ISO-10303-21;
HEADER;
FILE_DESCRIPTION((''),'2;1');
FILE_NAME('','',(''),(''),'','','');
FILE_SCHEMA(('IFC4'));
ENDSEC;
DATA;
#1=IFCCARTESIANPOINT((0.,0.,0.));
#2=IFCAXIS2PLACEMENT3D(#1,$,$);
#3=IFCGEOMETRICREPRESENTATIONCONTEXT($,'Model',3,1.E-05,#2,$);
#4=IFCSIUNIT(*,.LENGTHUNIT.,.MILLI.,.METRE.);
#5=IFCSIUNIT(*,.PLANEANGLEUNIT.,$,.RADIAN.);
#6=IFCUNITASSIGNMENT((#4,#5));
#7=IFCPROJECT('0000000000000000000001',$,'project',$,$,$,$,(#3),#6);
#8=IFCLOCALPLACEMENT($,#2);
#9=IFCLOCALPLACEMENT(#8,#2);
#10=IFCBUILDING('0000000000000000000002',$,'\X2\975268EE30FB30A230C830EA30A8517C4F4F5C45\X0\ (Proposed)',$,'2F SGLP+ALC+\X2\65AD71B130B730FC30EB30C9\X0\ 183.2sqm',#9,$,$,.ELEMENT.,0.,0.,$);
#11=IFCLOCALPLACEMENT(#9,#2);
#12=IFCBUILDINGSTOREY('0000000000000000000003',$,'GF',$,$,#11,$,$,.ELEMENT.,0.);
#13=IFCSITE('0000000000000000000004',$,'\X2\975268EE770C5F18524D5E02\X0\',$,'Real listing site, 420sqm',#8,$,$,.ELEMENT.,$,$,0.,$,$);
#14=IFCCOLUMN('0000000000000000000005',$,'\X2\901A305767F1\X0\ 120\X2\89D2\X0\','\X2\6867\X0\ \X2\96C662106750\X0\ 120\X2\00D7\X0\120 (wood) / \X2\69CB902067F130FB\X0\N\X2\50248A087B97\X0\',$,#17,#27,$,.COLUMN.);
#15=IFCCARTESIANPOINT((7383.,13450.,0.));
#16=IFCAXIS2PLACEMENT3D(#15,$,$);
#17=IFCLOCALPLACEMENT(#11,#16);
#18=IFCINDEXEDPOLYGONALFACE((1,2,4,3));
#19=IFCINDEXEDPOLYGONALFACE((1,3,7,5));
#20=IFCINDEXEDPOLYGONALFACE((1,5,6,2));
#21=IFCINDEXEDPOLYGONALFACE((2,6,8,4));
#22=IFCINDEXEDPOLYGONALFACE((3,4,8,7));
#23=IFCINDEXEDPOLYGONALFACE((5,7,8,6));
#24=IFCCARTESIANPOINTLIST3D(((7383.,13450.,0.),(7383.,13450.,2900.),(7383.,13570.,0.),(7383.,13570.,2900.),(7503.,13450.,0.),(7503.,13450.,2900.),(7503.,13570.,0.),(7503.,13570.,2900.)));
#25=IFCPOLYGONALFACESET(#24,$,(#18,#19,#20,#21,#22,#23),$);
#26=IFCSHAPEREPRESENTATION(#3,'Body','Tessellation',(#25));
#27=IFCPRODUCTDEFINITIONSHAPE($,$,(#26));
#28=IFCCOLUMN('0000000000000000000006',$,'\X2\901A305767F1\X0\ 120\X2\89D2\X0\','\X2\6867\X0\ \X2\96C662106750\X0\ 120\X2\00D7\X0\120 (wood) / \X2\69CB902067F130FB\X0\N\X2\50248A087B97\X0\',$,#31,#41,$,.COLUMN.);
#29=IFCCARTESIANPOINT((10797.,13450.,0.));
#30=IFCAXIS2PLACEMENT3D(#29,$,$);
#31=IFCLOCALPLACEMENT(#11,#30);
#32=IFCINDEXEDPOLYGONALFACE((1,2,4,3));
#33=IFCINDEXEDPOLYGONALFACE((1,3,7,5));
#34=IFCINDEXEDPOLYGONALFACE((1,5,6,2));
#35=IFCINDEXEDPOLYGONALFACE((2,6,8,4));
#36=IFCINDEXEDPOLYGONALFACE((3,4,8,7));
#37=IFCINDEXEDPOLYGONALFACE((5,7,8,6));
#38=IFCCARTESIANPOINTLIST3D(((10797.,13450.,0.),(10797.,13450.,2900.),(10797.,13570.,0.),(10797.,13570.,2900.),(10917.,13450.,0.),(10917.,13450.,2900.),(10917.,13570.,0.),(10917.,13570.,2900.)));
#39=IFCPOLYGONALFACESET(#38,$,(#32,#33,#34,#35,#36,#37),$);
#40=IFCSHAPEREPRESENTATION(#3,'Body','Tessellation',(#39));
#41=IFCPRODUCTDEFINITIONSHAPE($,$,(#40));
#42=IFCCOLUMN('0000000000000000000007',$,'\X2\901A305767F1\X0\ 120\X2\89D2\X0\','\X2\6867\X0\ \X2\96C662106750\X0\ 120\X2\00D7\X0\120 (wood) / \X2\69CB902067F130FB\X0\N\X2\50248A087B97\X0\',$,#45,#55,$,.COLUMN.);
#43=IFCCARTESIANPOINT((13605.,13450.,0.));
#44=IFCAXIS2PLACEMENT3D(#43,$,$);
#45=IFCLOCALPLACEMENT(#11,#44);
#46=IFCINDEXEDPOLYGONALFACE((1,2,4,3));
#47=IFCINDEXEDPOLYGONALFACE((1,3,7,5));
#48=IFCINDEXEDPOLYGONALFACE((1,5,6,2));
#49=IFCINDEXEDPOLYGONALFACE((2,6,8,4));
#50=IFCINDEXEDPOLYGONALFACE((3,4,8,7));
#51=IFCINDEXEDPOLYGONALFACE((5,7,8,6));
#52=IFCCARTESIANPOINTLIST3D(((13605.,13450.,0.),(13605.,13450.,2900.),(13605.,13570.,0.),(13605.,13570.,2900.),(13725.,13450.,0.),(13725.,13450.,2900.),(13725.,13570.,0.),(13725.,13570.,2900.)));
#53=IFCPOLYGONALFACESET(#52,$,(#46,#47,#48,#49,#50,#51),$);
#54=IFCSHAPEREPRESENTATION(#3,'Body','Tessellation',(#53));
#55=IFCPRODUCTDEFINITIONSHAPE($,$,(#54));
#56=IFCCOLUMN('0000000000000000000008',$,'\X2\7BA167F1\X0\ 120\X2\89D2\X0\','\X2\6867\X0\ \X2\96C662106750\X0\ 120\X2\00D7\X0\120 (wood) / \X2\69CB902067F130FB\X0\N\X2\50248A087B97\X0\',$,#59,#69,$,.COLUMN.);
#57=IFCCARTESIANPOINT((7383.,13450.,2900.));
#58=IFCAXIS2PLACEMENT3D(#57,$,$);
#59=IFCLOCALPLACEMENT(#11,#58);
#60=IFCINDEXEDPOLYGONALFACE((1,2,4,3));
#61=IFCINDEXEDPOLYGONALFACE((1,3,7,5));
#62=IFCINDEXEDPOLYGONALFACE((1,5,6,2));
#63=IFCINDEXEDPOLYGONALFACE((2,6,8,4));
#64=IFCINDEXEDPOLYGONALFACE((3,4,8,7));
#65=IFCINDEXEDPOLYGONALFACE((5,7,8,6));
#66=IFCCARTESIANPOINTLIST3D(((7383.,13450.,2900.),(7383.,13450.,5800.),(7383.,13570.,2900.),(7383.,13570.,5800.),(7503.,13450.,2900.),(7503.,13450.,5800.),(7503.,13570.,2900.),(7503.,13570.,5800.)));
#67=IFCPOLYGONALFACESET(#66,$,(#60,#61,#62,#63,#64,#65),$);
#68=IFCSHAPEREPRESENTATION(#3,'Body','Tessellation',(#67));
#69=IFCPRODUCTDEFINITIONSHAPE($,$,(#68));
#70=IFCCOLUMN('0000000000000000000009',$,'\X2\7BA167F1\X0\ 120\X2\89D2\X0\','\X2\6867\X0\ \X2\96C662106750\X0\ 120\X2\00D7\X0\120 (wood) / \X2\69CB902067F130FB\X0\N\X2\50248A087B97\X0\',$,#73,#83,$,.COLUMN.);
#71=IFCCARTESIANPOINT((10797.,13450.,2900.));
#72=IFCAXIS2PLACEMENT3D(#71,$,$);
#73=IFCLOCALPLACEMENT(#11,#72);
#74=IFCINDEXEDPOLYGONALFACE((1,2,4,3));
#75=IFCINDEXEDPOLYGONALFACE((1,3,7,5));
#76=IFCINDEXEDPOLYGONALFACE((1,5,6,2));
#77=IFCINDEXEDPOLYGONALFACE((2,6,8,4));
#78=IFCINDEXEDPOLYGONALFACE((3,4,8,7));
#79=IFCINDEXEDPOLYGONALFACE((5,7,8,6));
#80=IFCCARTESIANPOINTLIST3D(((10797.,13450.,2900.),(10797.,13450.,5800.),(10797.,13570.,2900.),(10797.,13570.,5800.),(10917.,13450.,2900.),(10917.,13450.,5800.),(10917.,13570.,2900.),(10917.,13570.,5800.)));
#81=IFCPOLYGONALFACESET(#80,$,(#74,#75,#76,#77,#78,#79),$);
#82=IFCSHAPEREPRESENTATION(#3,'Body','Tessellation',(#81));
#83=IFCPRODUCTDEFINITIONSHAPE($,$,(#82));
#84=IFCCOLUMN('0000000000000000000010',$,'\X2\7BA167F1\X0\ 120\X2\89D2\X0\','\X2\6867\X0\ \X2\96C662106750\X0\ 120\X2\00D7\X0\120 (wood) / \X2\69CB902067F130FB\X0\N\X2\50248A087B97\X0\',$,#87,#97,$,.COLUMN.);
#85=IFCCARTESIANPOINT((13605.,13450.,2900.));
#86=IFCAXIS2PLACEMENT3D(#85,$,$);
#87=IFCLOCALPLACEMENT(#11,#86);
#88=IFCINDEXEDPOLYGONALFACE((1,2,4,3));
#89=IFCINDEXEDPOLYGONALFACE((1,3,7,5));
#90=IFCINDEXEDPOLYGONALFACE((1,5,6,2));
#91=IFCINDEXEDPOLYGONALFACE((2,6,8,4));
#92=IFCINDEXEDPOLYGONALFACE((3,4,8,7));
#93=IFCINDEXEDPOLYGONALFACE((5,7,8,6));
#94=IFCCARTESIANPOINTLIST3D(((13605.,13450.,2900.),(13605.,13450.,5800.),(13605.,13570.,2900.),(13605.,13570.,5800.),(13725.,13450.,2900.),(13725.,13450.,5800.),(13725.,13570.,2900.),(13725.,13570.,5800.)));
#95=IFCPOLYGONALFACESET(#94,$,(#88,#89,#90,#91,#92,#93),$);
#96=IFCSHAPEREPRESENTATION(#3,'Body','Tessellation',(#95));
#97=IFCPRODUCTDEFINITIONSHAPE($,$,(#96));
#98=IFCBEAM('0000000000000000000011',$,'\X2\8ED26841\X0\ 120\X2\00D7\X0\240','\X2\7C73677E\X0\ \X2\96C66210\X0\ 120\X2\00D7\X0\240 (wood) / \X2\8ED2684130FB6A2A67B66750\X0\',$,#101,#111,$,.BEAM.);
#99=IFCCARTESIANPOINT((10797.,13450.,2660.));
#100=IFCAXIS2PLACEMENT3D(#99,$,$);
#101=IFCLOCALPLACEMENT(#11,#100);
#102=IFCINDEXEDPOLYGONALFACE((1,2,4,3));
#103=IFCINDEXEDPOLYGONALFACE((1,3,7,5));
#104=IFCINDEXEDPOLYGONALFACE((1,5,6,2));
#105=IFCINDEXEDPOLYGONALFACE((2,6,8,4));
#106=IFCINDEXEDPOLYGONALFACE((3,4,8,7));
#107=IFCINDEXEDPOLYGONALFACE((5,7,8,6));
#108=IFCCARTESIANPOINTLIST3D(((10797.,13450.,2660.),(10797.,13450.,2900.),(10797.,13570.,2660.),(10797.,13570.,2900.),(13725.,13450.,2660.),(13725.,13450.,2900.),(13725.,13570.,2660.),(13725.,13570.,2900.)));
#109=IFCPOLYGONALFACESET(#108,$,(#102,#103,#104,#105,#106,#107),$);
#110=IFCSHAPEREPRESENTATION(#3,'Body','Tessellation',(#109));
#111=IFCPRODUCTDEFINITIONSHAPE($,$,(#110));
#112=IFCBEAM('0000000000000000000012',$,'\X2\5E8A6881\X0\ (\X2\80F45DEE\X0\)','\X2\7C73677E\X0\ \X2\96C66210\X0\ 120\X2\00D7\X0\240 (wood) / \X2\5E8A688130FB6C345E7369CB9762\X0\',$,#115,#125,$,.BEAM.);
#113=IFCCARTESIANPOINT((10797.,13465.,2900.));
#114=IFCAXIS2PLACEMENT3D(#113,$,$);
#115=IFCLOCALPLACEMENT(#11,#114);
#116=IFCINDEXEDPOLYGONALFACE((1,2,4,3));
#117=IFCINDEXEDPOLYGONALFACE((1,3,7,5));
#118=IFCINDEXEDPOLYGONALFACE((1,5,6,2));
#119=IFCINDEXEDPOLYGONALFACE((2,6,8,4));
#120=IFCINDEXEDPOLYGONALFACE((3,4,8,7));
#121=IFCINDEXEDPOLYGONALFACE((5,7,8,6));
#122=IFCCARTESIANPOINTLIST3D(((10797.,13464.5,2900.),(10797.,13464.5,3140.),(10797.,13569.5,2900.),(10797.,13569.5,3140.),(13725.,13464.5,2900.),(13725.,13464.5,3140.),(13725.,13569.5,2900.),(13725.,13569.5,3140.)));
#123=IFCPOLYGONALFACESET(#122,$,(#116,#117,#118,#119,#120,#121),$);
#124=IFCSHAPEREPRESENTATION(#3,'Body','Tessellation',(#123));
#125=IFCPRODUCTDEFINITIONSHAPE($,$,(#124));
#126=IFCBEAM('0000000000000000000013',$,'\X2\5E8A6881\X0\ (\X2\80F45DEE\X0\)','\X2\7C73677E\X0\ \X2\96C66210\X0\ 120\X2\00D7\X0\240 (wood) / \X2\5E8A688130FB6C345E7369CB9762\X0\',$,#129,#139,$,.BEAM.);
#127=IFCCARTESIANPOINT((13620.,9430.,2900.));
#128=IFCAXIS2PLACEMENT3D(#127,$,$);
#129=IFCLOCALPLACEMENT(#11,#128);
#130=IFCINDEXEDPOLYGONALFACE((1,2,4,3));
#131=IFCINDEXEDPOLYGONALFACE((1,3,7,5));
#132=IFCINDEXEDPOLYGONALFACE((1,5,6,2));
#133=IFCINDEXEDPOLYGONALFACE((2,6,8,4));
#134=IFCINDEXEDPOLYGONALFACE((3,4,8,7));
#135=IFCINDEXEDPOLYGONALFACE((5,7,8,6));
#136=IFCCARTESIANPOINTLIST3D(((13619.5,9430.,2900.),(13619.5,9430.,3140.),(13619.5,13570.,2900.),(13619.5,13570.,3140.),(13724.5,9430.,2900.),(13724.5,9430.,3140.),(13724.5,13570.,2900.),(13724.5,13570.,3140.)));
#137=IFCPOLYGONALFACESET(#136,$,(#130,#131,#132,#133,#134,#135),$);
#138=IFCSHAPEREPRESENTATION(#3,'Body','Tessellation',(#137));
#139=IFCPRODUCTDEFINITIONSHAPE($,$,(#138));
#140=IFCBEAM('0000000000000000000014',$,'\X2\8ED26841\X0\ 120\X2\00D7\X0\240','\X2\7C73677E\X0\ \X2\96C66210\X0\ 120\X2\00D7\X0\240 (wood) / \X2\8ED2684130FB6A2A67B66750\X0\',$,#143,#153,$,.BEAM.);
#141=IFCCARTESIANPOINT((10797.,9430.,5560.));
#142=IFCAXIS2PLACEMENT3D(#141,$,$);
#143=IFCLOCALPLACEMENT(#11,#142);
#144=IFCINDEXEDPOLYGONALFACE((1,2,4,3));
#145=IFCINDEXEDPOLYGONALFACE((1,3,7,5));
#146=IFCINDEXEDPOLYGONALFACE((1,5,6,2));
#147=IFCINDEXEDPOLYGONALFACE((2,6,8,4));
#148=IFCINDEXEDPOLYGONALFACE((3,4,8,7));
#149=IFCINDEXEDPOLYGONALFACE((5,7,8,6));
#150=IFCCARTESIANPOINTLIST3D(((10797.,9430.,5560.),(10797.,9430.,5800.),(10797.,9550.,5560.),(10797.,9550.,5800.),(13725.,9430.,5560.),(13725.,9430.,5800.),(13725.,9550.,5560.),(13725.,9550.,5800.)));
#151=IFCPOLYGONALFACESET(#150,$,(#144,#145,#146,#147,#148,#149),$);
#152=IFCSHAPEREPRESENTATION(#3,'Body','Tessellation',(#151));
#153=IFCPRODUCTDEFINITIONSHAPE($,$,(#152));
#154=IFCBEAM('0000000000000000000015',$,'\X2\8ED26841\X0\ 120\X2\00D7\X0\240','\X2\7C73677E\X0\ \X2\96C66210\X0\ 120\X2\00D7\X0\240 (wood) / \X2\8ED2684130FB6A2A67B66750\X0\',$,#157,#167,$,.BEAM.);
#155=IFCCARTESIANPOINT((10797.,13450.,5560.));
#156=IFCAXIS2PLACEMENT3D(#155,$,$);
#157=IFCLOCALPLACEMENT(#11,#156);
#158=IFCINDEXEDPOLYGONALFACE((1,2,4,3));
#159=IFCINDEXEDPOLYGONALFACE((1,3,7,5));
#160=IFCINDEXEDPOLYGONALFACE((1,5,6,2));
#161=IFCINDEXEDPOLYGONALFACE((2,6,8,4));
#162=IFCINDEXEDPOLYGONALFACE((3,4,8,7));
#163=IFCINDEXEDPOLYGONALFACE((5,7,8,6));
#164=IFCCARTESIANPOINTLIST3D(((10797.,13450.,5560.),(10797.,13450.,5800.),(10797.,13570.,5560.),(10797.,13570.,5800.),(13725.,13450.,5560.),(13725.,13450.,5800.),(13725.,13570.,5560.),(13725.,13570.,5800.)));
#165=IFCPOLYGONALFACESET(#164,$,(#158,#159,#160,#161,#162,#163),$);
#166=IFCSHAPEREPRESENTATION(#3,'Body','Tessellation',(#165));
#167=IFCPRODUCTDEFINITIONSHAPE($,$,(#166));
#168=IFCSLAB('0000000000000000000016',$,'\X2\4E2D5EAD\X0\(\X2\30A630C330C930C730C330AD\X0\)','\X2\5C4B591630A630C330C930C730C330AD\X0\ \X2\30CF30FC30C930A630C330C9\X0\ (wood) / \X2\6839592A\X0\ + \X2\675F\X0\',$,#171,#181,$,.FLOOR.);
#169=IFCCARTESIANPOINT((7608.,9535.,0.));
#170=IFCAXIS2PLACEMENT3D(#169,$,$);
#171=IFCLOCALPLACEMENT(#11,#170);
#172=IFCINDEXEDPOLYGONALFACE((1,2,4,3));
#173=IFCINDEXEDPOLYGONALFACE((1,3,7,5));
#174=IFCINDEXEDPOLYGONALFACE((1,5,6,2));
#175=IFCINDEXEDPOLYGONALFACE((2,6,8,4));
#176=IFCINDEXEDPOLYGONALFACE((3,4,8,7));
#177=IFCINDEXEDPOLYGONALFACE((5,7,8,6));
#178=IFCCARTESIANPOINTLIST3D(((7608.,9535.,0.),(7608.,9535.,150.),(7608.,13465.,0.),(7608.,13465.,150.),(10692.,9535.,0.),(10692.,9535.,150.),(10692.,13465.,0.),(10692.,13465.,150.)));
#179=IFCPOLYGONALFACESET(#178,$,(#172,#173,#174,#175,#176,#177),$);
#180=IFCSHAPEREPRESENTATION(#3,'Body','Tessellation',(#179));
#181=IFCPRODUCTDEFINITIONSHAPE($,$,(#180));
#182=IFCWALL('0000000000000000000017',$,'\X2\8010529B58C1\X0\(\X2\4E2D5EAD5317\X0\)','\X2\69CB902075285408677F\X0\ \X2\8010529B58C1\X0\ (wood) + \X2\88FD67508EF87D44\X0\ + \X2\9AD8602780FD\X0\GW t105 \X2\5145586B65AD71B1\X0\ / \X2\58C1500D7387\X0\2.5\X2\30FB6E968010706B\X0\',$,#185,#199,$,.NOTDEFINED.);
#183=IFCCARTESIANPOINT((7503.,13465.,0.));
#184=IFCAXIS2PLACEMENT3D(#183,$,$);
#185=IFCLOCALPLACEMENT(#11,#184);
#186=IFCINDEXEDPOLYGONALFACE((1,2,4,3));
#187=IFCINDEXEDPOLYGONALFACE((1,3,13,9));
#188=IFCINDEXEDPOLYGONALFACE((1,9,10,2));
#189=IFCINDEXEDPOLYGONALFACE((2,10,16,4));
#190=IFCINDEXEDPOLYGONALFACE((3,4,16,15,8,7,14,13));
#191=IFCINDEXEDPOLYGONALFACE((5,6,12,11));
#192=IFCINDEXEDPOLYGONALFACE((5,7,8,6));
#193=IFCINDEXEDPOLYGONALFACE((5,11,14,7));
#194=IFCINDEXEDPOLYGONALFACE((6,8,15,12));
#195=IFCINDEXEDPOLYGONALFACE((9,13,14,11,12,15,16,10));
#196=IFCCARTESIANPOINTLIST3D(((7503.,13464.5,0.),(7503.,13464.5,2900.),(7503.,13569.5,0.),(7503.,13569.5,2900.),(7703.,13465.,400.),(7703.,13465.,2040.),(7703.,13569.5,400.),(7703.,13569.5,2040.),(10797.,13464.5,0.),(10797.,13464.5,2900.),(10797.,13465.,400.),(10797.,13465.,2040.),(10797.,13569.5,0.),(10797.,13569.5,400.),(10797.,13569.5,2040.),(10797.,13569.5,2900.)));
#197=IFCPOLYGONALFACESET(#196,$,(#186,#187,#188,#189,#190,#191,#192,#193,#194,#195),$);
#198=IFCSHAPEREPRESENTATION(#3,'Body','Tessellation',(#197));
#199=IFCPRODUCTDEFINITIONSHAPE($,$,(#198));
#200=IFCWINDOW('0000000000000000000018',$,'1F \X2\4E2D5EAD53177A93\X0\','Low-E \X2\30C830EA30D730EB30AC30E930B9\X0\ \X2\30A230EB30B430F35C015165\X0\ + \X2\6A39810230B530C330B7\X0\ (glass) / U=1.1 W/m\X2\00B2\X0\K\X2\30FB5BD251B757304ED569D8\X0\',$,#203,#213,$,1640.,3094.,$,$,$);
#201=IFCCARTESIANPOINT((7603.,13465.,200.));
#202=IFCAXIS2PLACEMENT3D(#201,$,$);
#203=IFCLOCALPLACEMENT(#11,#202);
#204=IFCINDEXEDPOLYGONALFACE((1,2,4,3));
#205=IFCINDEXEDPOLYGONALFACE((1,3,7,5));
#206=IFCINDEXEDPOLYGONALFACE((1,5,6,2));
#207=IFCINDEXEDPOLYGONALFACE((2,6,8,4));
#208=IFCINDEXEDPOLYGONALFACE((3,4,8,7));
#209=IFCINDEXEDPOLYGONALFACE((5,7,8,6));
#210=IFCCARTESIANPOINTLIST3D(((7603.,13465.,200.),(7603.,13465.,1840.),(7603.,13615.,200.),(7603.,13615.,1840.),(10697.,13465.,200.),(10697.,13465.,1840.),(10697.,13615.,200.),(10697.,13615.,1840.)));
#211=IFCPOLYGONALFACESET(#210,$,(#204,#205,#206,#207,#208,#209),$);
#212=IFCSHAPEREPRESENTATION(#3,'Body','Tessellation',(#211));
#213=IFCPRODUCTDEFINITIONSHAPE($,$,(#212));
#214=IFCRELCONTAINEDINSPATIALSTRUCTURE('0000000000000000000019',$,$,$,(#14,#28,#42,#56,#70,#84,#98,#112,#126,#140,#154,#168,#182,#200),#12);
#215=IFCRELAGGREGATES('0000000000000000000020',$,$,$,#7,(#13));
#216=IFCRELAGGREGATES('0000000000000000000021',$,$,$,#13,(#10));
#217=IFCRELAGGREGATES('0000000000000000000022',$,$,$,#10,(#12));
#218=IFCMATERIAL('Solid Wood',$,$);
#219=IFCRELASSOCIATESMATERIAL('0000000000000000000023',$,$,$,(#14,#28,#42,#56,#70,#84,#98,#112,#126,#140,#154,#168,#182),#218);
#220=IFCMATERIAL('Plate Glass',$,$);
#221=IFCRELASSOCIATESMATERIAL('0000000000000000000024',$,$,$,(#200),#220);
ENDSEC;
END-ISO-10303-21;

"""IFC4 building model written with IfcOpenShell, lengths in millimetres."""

from ifc_helpers import new_model, si_unit, frame, frame_2d, origin, place, context, project, spatial, rectangle, extrude, material, element, fill, save


model = new_model("IFC4")

# Units and contexts
model_context = context("Model", 3, precision=1e-05, world=origin())
ifc_project = project(units=[si_unit("LENGTHUNIT", "METRE", prefix="MILLI"), si_unit("PLANEANGLEUNIT", "RADIAN")], contexts=[model_context])

# Site, building, storey
site_placement = place(None, origin())
site = spatial("IfcSite", under=ifc_project, at=site_placement, Name="青森県弘前市", ObjectType="Real listing site, 420sqm", CompositionType="ELEMENT", RefElevation=0.0)
building_placement = place(site_placement, origin())
building = spatial("IfcBuilding", under=site, at=building_placement, Name="青森・アトリエ兼住居 (Proposed)", ObjectType="2F SGLP+ALC+断熱シールド 183.2sqm", CompositionType="ELEMENT", ElevationOfRefHeight=0.0, ElevationOfTerrain=0.0)
storey_placement = place(building_placement, origin())
storey = spatial("IfcBuildingStorey", under=building, at=storey_placement, Name="GF", CompositionType="ELEMENT", Elevation=0.0)

# Columns
ifc_material_1 = material(Name="Solid Wood")
column_1_placement = place(storey_placement, frame((7383.0, 13450.0, 0.0)))
element("IfcColumn", 1, at=column_1_placement, inside=storey, material=ifc_material_1, Name="通し柱 120角", Description="桧 集成材 120×120 (wood) / 構造柱・N値計算", PredefinedType="COLUMN", context=model_context, shape_type="SweptSolid", body=[
    extrude(rectangle(XDim=120.0, YDim=120.0, at=frame_2d((60.0, 60.0))), frame((7383.0, 13450.0, 0.0)), (0.0, 0.0, 1.0), 2900.0),
])
column_2_placement = place(storey_placement, frame((10797.0, 13450.0, 0.0)))
element("IfcColumn", 2, at=column_2_placement, inside=storey, material=ifc_material_1, Name="通し柱 120角", Description="桧 集成材 120×120 (wood) / 構造柱・N値計算", PredefinedType="COLUMN", context=model_context, shape_type="SweptSolid", body=[
    extrude(rectangle(XDim=120.0, YDim=120.0, at=frame_2d((60.0, 60.0))), frame((10797.0, 13450.0, 0.0)), (0.0, 0.0, 1.0), 2900.0),
])
column_3_placement = place(storey_placement, frame((13605.0, 13450.0, 0.0)))
element("IfcColumn", 3, at=column_3_placement, inside=storey, material=ifc_material_1, Name="通し柱 120角", Description="桧 集成材 120×120 (wood) / 構造柱・N値計算", PredefinedType="COLUMN", context=model_context, shape_type="SweptSolid", body=[
    extrude(rectangle(XDim=120.0, YDim=120.0, at=frame_2d((60.0, 60.0))), frame((13605.0, 13450.0, 0.0)), (0.0, 0.0, 1.0), 2900.0),
])
column_4_placement = place(storey_placement, frame((7383.0, 13450.0, 2900.0)))
element("IfcColumn", 4, at=column_4_placement, inside=storey, material=ifc_material_1, Name="管柱 120角", Description="桧 集成材 120×120 (wood) / 構造柱・N値計算", PredefinedType="COLUMN", context=model_context, shape_type="SweptSolid", body=[
    extrude(rectangle(XDim=120.0, YDim=120.0, at=frame_2d((60.0, 60.0))), frame((7383.0, 13450.0, 2900.0)), (0.0, 0.0, 1.0), 2900.0),
])
column_5_placement = place(storey_placement, frame((10797.0, 13450.0, 2900.0)))
element("IfcColumn", 5, at=column_5_placement, inside=storey, material=ifc_material_1, Name="管柱 120角", Description="桧 集成材 120×120 (wood) / 構造柱・N値計算", PredefinedType="COLUMN", context=model_context, shape_type="SweptSolid", body=[
    extrude(rectangle(XDim=120.0, YDim=120.0, at=frame_2d((60.0, 60.0))), frame((10797.0, 13450.0, 2900.0)), (0.0, 0.0, 1.0), 2900.0),
])
column_6_placement = place(storey_placement, frame((13605.0, 13450.0, 2900.0)))
element("IfcColumn", 6, at=column_6_placement, inside=storey, material=ifc_material_1, Name="管柱 120角", Description="桧 集成材 120×120 (wood) / 構造柱・N値計算", PredefinedType="COLUMN", context=model_context, shape_type="SweptSolid", body=[
    extrude(rectangle(XDim=120.0, YDim=120.0, at=frame_2d((60.0, 60.0))), frame((13605.0, 13450.0, 2900.0)), (0.0, 0.0, 1.0), 2900.0),
])

# Beams
beam_1_placement = place(storey_placement, frame((10797.0, 13450.0, 2660.0)))
element("IfcBeam", 7, at=beam_1_placement, inside=storey, material=ifc_material_1, Name="軒桁 120×240", Description="米松 集成 120×240 (wood) / 軒桁・横架材", PredefinedType="BEAM", context=model_context, shape_type="SweptSolid", body=[
    extrude(rectangle(XDim=2928.0, YDim=120.0, at=frame_2d((1464.0, 60.0))), frame((10797.0, 13450.0, 2660.0)), (0.0, 0.0, 1.0), 240.0),
])
beam_2_placement = place(storey_placement, frame((10797.0, 13465.0, 2900.0)))
element("IfcBeam", 8, at=beam_2_placement, inside=storey, material=ifc_material_1, Name="床梁 (胴差)", Description="米松 集成 120×240 (wood) / 床梁・水平構面", PredefinedType="BEAM", context=model_context, shape_type="SweptSolid", body=[
    extrude(rectangle(XDim=2928.0, YDim=105.0, at=frame_2d((1464.0, 52.0))), frame((10797.0, 13465.0, 2900.0)), (0.0, 0.0, 1.0), 240.0),
])
beam_3_placement = place(storey_placement, frame((13620.0, 9430.0, 2900.0)))
element("IfcBeam", 9, at=beam_3_placement, inside=storey, material=ifc_material_1, Name="床梁 (胴差)", Description="米松 集成 120×240 (wood) / 床梁・水平構面", PredefinedType="BEAM", context=model_context, shape_type="SweptSolid", body=[
    extrude(rectangle(XDim=105.0, YDim=4140.0, at=frame_2d((52.0, 2070.0))), frame((13620.0, 9430.0, 2900.0)), (0.0, 0.0, 1.0), 240.0),
])
beam_4_placement = place(storey_placement, frame((10797.0, 9430.0, 5560.0)))
element("IfcBeam", 10, at=beam_4_placement, inside=storey, material=ifc_material_1, Name="軒桁 120×240", Description="米松 集成 120×240 (wood) / 軒桁・横架材", PredefinedType="BEAM", context=model_context, shape_type="SweptSolid", body=[
    extrude(rectangle(XDim=2928.0, YDim=120.0, at=frame_2d((1464.0, 60.0))), frame((10797.0, 9430.0, 5560.0)), (0.0, 0.0, 1.0), 240.0),
])
beam_5_placement = place(storey_placement, frame((10797.0, 13450.0, 5560.0)))
element("IfcBeam", 11, at=beam_5_placement, inside=storey, material=ifc_material_1, Name="軒桁 120×240", Description="米松 集成 120×240 (wood) / 軒桁・横架材", PredefinedType="BEAM", context=model_context, shape_type="SweptSolid", body=[
    extrude(rectangle(XDim=2928.0, YDim=120.0, at=frame_2d((1464.0, 60.0))), frame((10797.0, 13450.0, 5560.0)), (0.0, 0.0, 1.0), 240.0),
])

# Slab
slab_placement = place(storey_placement, frame((7608.0, 9535.0, 0.0)))
element("IfcSlab", 12, at=slab_placement, inside=storey, material=ifc_material_1, Name="中庭(ウッドデッキ)", Description="屋外ウッドデッキ ハードウッド (wood) / 根太 + 束", PredefinedType="FLOOR", context=model_context, shape_type="SweptSolid", body=[
    extrude(rectangle(XDim=3084.0, YDim=3930.0, at=frame_2d((1542.0, 1965.0))), frame((7608.0, 9535.0, 0.0)), (0.0, 0.0, 1.0), 150.0),
])

# Wall, opening, window
wall_1_placement = place(storey_placement, frame((7503.0, 13465.0, 0.0)))
wall_1 = element("IfcWall", 13, at=wall_1_placement, inside=storey, material=ifc_material_1, Name="耐力壁(中庭北)", Description="構造用合板 耐力壁 (wood) + 製材軸組 + 高性能GW t105 充填断熱 / 壁倍率2.5・準耐火", PredefinedType="NOTDEFINED", context=model_context, shape_type="SweptSolid", body=[
    extrude(rectangle(XDim=3294.0, YDim=105.0, at=frame_2d((1647.0, 52.0))), frame((7503.0, 13465.0, 0.0)), (0.0, 0.0, 1.0), 2900.0),
])
opening_1_placement = place(storey_placement, frame((7603.0, 13465.0, 200.0)))
opening_1 = element("IfcOpeningElement", 14, at=opening_1_placement, cuts=wall_1, PredefinedType="NOTDEFINED", context=model_context, shape_type="SweptSolid", body=[
    extrude(rectangle(XDim=3094.0, YDim=150.0, at=frame_2d((1547.0, 75.0))), frame((7603.0, 13465.0, 200.0)), (0.0, 0.0, 1.0), 1640.0),
])
ifc_material_2 = material(Name="Plate Glass")
window_1_placement = place(storey_placement, frame((7603.0, 13465.0, 200.0)))
window_1 = element("IfcWindow", 15, at=window_1_placement, inside=storey, material=ifc_material_2, Name="1F 中庭北窓", Description="Low-E トリプルガラス アルゴン封入 + 樹脂サッシ (glass) / U=1.1 W/m²K・寒冷地仕様", OverallHeight=1640.0, OverallWidth=3094.0, context=model_context, shape_type="SweptSolid", body=[
    extrude(rectangle(XDim=3094.0, YDim=150.0, at=frame_2d((1547.0, 75.0))), frame((7603.0, 13465.0, 200.0)), (0.0, 0.0, 1.0), 1640.0),
])
fill(opening_1, window_1)

save(model, "model.ifc")
